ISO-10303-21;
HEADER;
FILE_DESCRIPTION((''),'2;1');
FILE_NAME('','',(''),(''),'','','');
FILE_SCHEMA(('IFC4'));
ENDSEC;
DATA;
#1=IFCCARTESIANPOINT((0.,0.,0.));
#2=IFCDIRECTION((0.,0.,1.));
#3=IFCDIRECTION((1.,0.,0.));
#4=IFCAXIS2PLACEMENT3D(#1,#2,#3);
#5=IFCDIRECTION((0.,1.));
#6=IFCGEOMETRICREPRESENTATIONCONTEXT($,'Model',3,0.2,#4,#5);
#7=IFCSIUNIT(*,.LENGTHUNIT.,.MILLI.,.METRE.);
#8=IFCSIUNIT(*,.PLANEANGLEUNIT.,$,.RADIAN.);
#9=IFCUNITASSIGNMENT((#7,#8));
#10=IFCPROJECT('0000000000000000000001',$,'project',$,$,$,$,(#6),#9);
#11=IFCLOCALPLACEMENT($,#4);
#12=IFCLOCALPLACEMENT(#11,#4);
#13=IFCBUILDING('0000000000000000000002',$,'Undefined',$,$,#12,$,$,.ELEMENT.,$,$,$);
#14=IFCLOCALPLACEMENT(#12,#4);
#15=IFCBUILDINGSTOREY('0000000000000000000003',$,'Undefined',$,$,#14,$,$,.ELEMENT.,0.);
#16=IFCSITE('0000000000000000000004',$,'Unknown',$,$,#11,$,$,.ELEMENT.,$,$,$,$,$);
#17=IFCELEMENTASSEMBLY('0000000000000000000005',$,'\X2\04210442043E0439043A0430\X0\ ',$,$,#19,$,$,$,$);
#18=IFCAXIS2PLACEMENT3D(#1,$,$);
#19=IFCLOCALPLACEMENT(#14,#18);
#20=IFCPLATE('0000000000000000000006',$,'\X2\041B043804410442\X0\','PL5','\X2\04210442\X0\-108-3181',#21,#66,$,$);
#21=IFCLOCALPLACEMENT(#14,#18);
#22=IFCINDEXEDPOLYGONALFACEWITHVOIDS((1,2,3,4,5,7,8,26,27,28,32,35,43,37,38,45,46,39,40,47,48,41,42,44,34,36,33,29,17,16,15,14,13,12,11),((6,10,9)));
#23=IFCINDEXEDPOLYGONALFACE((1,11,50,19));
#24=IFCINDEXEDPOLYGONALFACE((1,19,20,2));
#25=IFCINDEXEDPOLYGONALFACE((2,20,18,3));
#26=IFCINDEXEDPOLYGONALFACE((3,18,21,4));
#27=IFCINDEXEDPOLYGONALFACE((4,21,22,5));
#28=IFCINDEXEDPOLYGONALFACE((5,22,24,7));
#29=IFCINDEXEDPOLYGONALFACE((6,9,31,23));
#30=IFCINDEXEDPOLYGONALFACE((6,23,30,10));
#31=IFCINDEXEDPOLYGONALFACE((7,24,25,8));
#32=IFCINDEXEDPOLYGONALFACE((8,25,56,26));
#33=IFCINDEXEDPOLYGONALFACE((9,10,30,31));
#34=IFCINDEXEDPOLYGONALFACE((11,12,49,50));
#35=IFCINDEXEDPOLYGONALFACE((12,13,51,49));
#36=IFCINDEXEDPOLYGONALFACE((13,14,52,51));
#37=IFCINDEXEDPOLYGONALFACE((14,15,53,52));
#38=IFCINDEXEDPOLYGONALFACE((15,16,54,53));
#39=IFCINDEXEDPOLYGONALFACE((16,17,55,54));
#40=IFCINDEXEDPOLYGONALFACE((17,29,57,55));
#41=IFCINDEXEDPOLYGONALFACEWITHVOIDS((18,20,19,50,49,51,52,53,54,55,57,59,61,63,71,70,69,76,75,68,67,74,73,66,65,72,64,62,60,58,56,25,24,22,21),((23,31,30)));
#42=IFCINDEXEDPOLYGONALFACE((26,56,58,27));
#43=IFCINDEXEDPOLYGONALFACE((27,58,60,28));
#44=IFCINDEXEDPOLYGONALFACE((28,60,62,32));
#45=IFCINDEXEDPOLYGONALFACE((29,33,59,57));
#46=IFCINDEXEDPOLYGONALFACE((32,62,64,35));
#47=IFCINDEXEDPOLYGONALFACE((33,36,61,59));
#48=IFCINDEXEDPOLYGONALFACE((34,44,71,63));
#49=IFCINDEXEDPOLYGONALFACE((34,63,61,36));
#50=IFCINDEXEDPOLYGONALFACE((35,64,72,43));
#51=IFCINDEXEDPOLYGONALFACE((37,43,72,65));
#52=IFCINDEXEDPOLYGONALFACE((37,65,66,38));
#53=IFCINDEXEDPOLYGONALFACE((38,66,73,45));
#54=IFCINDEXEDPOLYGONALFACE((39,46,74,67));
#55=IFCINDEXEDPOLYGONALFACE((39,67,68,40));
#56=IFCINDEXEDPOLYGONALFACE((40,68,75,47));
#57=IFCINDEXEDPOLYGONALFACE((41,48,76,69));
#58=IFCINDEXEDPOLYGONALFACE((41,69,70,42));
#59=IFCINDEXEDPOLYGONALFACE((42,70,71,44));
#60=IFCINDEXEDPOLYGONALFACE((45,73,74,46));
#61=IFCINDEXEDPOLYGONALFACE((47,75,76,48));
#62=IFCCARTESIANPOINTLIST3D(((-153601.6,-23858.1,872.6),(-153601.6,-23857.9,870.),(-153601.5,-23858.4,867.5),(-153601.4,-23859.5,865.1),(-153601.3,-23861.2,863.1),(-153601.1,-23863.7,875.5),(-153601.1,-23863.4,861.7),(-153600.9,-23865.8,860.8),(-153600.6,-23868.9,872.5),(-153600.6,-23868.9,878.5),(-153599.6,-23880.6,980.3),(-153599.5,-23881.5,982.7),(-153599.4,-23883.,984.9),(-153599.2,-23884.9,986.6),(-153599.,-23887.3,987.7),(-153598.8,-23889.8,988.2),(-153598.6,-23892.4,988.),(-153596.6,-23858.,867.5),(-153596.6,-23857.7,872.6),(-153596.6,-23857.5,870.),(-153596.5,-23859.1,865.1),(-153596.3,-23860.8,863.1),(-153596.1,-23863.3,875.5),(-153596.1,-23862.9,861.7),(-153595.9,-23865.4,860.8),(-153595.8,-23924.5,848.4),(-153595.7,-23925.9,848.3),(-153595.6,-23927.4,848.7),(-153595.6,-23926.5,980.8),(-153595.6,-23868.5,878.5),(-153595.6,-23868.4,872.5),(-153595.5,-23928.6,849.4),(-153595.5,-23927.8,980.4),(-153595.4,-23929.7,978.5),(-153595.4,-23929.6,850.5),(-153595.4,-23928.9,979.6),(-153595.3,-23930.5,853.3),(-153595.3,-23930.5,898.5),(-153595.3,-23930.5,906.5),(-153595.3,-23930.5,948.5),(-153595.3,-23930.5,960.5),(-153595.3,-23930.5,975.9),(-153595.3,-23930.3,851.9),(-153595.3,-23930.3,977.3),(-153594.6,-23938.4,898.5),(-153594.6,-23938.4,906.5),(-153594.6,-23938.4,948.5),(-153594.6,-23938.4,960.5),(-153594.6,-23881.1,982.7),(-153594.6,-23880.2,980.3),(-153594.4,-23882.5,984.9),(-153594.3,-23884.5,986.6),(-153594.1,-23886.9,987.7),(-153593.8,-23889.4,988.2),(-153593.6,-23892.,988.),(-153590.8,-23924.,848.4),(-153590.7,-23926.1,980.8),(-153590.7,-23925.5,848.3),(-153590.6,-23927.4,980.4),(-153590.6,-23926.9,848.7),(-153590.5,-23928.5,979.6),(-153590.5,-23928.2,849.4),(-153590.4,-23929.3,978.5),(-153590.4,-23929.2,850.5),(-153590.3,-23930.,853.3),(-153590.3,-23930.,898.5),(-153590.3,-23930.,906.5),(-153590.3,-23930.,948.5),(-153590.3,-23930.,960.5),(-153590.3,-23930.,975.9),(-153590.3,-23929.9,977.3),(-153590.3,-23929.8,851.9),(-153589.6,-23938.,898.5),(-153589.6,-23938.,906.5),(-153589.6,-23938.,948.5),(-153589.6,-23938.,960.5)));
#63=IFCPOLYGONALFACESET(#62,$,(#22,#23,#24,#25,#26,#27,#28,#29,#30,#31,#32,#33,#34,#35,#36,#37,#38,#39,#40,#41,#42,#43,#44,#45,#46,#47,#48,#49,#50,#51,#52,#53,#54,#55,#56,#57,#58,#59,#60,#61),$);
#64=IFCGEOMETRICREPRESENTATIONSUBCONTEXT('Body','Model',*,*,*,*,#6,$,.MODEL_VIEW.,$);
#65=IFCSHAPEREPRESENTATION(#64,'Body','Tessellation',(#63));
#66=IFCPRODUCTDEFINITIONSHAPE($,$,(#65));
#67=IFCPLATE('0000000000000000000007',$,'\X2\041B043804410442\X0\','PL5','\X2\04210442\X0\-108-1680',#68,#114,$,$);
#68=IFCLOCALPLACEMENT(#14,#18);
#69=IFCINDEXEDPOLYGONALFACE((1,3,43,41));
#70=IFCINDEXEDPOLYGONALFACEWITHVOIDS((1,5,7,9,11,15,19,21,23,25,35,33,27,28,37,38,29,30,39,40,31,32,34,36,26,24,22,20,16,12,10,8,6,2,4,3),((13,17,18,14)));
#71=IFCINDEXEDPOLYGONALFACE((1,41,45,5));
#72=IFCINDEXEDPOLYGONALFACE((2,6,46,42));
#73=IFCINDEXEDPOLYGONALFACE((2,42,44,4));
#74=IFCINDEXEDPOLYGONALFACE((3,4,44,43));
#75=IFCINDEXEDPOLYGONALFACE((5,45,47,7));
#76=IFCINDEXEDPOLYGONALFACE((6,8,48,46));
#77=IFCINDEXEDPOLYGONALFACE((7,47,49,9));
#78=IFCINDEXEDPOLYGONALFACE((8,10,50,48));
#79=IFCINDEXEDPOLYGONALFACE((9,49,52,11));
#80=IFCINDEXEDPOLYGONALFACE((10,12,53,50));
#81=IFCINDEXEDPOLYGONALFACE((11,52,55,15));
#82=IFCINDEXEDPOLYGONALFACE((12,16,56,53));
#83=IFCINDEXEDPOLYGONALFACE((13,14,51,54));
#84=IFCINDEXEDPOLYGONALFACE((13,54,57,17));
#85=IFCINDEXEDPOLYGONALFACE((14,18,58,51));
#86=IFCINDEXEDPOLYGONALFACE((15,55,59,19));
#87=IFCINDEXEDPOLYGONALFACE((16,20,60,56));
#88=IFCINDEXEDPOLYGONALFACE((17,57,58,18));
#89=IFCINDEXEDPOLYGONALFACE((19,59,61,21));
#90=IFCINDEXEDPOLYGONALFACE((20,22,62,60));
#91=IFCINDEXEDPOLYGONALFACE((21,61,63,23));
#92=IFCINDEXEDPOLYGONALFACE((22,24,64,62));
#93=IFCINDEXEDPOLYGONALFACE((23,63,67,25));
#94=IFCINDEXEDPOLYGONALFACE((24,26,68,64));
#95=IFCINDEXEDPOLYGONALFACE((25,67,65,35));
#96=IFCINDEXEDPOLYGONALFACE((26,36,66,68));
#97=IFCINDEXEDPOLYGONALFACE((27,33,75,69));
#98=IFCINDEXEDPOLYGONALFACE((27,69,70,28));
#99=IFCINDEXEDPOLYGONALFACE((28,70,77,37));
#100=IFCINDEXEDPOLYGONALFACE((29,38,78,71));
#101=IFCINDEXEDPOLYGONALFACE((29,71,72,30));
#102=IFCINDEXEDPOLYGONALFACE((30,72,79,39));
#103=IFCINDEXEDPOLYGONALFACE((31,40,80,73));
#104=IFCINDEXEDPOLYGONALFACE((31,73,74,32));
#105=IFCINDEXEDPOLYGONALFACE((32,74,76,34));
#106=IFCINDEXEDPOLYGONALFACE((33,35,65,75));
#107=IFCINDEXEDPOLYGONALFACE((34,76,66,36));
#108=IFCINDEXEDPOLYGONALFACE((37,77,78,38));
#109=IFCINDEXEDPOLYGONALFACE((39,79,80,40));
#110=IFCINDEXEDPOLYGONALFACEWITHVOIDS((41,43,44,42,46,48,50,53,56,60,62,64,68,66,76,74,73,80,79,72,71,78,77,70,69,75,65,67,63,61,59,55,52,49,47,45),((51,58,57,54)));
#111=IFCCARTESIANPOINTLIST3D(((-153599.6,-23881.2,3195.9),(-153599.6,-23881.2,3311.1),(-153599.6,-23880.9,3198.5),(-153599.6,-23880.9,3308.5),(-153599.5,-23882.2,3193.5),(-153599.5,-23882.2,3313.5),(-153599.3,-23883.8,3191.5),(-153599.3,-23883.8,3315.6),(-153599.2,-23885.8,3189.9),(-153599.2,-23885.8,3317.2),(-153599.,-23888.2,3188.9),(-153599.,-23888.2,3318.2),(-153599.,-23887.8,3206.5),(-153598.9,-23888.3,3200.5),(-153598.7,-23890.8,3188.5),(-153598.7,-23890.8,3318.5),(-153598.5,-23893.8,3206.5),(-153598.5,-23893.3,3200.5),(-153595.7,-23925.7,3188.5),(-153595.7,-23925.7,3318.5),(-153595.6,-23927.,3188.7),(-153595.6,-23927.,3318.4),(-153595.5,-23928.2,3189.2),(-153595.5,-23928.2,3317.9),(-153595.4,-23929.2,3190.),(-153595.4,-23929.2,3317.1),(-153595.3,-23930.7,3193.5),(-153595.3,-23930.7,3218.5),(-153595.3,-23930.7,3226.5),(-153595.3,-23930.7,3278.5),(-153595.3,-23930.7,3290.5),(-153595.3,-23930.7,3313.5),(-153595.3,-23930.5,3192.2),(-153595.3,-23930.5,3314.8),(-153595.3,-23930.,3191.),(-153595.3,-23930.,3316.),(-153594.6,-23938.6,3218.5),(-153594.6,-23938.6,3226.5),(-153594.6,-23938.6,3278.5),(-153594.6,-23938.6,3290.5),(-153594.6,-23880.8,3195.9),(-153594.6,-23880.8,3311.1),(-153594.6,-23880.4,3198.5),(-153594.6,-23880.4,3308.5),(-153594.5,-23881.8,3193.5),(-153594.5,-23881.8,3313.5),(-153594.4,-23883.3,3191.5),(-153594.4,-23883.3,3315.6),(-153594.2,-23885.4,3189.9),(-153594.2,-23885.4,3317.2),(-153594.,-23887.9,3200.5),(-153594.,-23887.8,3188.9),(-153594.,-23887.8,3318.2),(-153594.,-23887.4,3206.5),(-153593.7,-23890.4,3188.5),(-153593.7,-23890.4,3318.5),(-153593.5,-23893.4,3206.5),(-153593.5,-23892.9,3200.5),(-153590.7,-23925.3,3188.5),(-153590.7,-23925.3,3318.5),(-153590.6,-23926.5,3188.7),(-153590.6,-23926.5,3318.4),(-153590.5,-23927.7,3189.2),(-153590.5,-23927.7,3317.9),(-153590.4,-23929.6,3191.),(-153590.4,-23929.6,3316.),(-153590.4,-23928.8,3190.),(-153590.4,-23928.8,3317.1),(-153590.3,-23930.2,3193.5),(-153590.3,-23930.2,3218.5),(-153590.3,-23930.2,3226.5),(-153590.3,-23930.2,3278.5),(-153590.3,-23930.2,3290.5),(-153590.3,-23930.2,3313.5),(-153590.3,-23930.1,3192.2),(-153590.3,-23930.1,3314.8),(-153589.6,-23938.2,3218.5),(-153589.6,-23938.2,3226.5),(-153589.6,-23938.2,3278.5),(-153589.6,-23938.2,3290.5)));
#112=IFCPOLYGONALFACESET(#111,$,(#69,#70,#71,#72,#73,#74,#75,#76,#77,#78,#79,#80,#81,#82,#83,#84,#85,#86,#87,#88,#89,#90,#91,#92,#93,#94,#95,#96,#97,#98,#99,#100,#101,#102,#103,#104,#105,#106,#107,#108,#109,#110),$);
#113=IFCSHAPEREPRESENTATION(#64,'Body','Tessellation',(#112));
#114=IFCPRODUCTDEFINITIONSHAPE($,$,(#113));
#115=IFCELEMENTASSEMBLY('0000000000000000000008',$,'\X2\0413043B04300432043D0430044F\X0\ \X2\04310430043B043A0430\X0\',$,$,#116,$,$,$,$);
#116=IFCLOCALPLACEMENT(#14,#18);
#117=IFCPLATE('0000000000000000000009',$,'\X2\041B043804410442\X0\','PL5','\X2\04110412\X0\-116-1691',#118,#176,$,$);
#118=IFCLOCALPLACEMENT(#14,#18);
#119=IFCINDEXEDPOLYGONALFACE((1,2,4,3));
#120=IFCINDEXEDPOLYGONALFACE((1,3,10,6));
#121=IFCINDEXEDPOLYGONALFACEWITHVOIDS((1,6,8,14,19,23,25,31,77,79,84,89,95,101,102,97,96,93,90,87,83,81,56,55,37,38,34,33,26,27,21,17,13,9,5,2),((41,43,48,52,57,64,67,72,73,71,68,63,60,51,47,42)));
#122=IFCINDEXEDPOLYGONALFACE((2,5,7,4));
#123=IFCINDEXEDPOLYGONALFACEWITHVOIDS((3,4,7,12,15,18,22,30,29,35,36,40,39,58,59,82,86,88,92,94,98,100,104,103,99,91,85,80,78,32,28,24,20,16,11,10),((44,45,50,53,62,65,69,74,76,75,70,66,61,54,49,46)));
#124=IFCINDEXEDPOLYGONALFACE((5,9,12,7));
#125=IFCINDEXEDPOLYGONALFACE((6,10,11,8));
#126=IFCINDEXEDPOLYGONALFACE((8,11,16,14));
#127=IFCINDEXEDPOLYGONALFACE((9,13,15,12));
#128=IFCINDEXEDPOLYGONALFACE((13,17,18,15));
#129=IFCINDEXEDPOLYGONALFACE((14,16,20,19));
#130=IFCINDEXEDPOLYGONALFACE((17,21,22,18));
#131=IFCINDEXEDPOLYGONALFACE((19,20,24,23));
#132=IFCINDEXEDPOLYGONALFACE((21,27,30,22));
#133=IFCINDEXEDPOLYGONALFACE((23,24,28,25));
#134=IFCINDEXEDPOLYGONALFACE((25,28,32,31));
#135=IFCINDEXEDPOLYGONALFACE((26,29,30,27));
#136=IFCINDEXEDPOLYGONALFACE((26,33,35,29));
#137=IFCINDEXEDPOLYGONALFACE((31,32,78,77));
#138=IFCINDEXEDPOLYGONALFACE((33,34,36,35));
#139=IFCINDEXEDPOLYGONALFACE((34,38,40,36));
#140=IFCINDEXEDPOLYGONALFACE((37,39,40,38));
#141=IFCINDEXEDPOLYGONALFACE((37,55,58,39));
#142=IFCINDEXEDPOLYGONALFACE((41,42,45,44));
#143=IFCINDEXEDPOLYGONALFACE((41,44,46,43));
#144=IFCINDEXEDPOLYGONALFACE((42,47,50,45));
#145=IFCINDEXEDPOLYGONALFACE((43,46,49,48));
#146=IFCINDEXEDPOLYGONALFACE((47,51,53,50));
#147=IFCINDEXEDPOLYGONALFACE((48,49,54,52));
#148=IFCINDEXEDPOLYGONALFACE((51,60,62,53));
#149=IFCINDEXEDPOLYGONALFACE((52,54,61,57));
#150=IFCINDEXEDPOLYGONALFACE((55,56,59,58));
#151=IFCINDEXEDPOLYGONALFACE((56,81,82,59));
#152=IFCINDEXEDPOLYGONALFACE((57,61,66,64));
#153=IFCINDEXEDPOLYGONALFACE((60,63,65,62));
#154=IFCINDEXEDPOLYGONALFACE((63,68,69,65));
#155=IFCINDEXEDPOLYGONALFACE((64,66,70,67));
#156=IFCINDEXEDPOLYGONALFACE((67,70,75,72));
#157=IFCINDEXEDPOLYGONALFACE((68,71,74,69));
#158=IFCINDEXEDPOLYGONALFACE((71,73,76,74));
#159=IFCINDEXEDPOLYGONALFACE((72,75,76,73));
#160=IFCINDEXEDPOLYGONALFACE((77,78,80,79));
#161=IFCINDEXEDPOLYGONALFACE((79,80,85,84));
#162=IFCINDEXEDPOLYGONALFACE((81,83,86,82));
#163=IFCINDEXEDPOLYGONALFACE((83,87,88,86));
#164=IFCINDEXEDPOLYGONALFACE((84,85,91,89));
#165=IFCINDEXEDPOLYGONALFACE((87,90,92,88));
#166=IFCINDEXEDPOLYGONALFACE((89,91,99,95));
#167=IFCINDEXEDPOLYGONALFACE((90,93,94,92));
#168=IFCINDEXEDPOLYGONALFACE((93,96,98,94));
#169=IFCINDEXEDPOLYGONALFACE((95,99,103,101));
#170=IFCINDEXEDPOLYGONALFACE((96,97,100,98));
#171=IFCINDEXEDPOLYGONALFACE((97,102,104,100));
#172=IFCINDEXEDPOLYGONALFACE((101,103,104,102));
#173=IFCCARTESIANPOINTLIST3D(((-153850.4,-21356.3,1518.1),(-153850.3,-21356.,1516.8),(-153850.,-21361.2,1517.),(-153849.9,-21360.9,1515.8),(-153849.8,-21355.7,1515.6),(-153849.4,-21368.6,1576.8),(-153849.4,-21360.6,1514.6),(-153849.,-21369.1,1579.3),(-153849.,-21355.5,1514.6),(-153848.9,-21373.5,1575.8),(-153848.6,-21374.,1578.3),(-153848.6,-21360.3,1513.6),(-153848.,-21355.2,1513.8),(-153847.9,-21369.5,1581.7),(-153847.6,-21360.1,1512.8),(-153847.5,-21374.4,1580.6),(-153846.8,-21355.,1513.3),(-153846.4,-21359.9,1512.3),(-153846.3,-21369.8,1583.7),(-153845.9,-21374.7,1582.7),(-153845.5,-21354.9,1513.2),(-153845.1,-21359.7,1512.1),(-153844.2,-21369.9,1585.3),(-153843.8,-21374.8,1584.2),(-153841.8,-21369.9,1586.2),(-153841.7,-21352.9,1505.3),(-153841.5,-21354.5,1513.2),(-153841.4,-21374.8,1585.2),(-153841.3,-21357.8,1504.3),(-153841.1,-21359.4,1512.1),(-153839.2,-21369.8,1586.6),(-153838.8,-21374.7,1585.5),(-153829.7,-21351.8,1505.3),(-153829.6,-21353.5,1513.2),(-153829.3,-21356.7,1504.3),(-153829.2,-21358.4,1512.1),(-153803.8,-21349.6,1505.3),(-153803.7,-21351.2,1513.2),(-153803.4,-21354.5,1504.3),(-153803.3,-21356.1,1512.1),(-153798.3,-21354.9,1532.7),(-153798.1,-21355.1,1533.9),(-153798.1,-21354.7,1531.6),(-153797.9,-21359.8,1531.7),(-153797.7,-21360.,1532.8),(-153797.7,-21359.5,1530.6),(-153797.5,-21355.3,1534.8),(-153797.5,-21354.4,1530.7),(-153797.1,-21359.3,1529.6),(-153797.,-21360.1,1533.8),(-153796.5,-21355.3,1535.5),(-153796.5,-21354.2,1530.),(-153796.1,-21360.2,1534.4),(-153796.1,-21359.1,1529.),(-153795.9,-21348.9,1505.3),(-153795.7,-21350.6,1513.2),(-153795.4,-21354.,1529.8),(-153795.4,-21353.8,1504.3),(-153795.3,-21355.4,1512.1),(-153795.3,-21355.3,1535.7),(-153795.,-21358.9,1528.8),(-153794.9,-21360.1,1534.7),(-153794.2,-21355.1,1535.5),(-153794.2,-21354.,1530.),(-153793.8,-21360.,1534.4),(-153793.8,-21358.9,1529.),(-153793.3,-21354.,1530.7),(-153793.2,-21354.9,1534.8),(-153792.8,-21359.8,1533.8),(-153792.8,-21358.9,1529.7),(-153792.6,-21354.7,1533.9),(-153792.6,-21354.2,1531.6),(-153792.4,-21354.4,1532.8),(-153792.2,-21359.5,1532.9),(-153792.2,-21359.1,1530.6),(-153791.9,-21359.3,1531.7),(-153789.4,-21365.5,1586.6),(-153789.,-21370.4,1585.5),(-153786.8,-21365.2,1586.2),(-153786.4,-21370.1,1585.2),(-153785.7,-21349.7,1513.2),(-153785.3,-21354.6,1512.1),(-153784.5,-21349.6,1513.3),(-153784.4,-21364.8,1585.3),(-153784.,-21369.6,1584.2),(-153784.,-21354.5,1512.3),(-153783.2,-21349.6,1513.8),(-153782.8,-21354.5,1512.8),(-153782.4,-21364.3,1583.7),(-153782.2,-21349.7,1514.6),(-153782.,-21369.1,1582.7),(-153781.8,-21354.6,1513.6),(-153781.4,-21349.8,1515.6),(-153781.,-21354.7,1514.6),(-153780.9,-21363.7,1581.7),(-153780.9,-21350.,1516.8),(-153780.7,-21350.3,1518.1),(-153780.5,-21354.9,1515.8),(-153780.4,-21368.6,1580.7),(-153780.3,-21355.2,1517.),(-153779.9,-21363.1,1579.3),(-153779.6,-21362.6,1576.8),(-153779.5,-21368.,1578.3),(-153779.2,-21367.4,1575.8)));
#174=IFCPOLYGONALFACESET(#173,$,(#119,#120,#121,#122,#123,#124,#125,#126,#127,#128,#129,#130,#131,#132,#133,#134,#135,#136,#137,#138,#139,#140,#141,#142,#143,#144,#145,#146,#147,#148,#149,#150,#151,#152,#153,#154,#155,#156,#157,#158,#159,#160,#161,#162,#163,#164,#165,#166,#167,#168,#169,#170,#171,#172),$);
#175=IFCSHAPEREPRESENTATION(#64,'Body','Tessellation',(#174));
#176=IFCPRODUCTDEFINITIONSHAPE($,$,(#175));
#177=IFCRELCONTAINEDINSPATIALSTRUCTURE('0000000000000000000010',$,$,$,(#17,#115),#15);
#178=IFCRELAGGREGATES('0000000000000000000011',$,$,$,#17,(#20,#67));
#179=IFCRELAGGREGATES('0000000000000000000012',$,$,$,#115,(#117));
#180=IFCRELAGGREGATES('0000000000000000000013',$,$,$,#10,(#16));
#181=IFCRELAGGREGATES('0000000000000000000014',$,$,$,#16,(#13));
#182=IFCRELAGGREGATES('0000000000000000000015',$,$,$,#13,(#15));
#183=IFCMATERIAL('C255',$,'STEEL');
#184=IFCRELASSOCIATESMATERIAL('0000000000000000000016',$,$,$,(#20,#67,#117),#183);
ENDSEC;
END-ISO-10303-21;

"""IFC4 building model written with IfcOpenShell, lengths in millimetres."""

from ifc_helpers import new_model, si_unit, direction, frame, origin_with_axes, place, context, subcontext, project, spatial, line, arc, indexed_curve, outline, extrude, material, element, aggregate, save


model = new_model("IFC4")

# Units and contexts
model_context = context("Model", 3, precision=0.2, world=origin_with_axes(), true_north=direction((0.0, 1.0)))
body_context = subcontext(model_context, "Body", "Model", "MODEL_VIEW")
ifc_project = project(units=[si_unit("LENGTHUNIT", "METRE", prefix="MILLI"), si_unit("PLANEANGLEUNIT", "RADIAN")], contexts=[model_context])

# Site, building, storey
site_placement = place(None, origin_with_axes())
site = spatial("IfcSite", under=ifc_project, at=site_placement, Name="Unknown", CompositionType="ELEMENT")
building_placement = place(site_placement, origin_with_axes())
building = spatial("IfcBuilding", under=site, at=building_placement, Name="Undefined", CompositionType="ELEMENT")
storey_placement = place(building_placement, origin_with_axes())
storey = spatial("IfcBuildingStorey", under=building, at=storey_placement, Name="Undefined", CompositionType="ELEMENT", Elevation=0.0)

# Element assemblies, plates, voiding features
ifc_material_1 = material(Name="C255", Category="STEEL")
assembly_1_placement = place(storey_placement, frame((-153594.3, -23970.7, 698.5), z_axis=(-0.086114, 0.996285, 0.0), x_axis=(0.0, 0.0, 1.0)))
assembly_1 = element("IfcElementAssembly", 1, at=assembly_1_placement, inside=storey, Name="Стойка ")
plate_1_placement = place(assembly_1_placement, frame((164.3, 5.0, 114.9), z_axis=(-0.000024, 1.0, 0.0), x_axis=(0.978653, 0.000024, -0.205517)))
plate_1 = element("IfcPlate", 2, at=plate_1_placement, material=ifc_material_1, Name="Лист", Description="PL5", ObjectType="Ст-108-3181", context=body_context, shape_type="SolidModel", body=[
    extrude(outline(indexed_curve([(0.0, 10.0), (2.9, 2.9), (10.0, 0.0), (120.0, 0.0), (127.1, 2.9), (130.0, 10.0), (130.0, 44.9), (128.9, 48.1), (126.0, 49.8), (110.9, 53.0), (112.6, 60.8), (100.8, 63.3), (99.2, 55.5), (58.1, 64.1), (59.7, 71.9), (51.9, 73.6), (50.3, 65.7), (6.0, 75.0), (1.8, 74.0), (0.0, 70.1)], segments=[arc(1, 2, 3), line(3, 4), arc(4, 5, 6), line(6, 7), arc(7, 8, 9), line(9, 10, 11, 12, 13, 14, 15, 16, 17, 18), arc(18, 19, 20), line(20, 1)])), frame((0.0, 0.0, 2.5), z_axis=(0.0, 0.0, 1.0), x_axis=(1.0, 0.0, 0.0)), (0.0, 0.0, -1.0), 5.0),
])
voiding_feature_1_placement = place(plate_1_placement, frame((15.0, 10.0, 10.0), z_axis=(-0.202559, -0.97927, 0.0), x_axis=(0.0, 0.0, -1.0)))
element("IfcVoidingFeature", 3, at=voiding_feature_1_placement, cuts=plate_1, Name="Балка", ObjectType="(?)", PredefinedType="HOLE", context=body_context, shape_type="SolidModel", body=[
    extrude(outline(indexed_curve([(0.0, -3.0), (5.2, 0.0), (0.0, 3.0)], segments=[line(1, 2, 3, 1)])), frame((0.0, 0.0, 0.0), z_axis=(-1.0, 0.0, 0.0), x_axis=(0.0, 0.0, 1.0)), (0.0, 0.0, -1.0), 20.0),
])
plate_2_placement = place(assembly_1_placement, frame((2490.0, 5.0, 90.0), z_axis=(0.000024, 1.0, 0.0), x_axis=(1.0, -0.000024, 0.0)))
plate_2 = element("IfcPlate", 4, at=plate_2_placement, material=ifc_material_1, Name="Лист", Description="PL5", ObjectType="Ст-108-1680", context=body_context, shape_type="SolidModel", body=[
    extrude(outline(indexed_curve([(0.0, 10.0), (2.9, 2.9), (10.0, 0.0), (120.0, 0.0), (127.1, 2.9), (130.0, 10.0), (130.0, 45.0), (128.5, 48.5), (125.0, 50.0), (102.0, 50.0), (102.0, 58.0), (90.0, 58.0), (90.0, 50.0), (38.0, 50.0), (38.0, 58.0), (30.0, 58.0), (30.0, 50.0), (5.0, 50.0), (1.5, 48.5), (0.0, 45.0)], segments=[arc(1, 2, 3), line(3, 4), arc(4, 5, 6), line(6, 7), arc(7, 8, 9), line(9, 10, 11, 12, 13, 14, 15, 16, 17, 18), arc(18, 19, 20), line(20, 1)])), frame((0.0, 0.0, 2.5), z_axis=(0.0, 0.0, 1.0), x_axis=(1.0, 0.0, 0.0)), (0.0, 0.0, -1.0), 5.0),
])
voiding_feature_2_placement = place(plate_2_placement, frame((15.0, 10.0, 10.0), z_axis=(0.003022, -0.999995, 0.0), x_axis=(0.0, 0.0, -1.0)))
element("IfcVoidingFeature", 5, at=voiding_feature_2_placement, cuts=plate_2, Name="Балка", ObjectType="(?)", PredefinedType="HOLE", context=body_context, shape_type="SolidModel", body=[
    extrude(outline(indexed_curve([(2.5, -3.0), (3.0, 3.0), (-3.0, 3.0), (-2.5, -3.0)], segments=[line(1, 2, 3, 4, 1)])), frame((0.0, 0.0, 0.0), z_axis=(-1.0, 0.0, 0.0), x_axis=(0.0, 0.0, 1.0)), (0.0, 0.0, -1.0), 20.0),
])
assembly_2_placement = place(storey_placement, frame((-153839.8, -21131.3, 1498.5), z_axis=(-0.996285, -0.086114, 0.000024), x_axis=(0.084276, -0.975018, -0.205517)))
assembly_2 = element("IfcElementAssembly", 6, at=assembly_2_placement, inside=storey, Name="Главная балка")
plate_3_placement = place(assembly_2_placement, frame((217.0, 135.0, -40.0), z_axis=(1.0, 0.000054, 0.0), x_axis=(0.0, -0.000054, 1.0)))
plate_3 = element("IfcPlate", 7, at=plate_3_placement, material=ifc_material_1, Name="Лист", Description="PL5", ObjectType="БВ-116-1691", context=body_context, shape_type="SolidModel", body=[
    extrude(outline(indexed_curve([(0.0, 10.0), (2.9, 2.9), (10.0, 0.0), (60.0, 0.0), (67.1, 2.9), (70.0, 10.0), (70.0, 70.0), (68.5, 73.5), (65.0, 75.0), (61.0, 75.0), (61.0, 83.0), (49.0, 83.0), (49.0, 75.0), (23.0, 75.0), (23.0, 83.0), (15.0, 83.0), (15.0, 75.0), (5.0, 75.0), (1.5, 73.5), (0.0, 70.0)], segments=[arc(1, 2, 3), line(3, 4), arc(4, 5, 6), line(6, 7), arc(7, 8, 9), line(9, 10, 11, 12, 13, 14, 15, 16, 17, 18), arc(18, 19, 20), line(20, 1)])), frame((0.0, 0.0, 2.5), z_axis=(0.0, 0.0, 1.0), x_axis=(1.0, 0.0, 0.0)), (0.0, 0.0, -1.0), 5.0),
])
voiding_feature_3_placement = place(plate_3_placement, frame((15.0, 55.0, 10.0), z_axis=(0.007997, -0.999968, -0.000026), x_axis=(0.0, 0.000026, -1.0)))
element("IfcVoidingFeature", 8, at=voiding_feature_3_placement, cuts=plate_3, Name="Балка", ObjectType="(?)", PredefinedType="HOLE", context=body_context, shape_type="SolidModel", body=[
    extrude(outline(indexed_curve([(3.0, 0.0), (2.8, 1.1), (2.1, 2.1), (1.1, 2.8), (0.0, 3.0), (-1.1, 2.8), (-2.1, 2.1), (-2.8, 1.1), (-3.0, 0.0), (-2.8, -1.1), (-2.1, -2.1), (-1.1, -2.8), (0.0, -3.0), (1.1, -2.8), (2.1, -2.1), (2.8, -1.1)], segments=[line(1, 2, 3, 4, 5, 6, 7, 8, 9, 10, 11, 12, 13, 14, 15, 16, 1)])), frame((0.0, 0.0, 0.0), z_axis=(-1.0, 0.0, 0.0), x_axis=(0.0, 0.0, 1.0)), (0.0, 0.0, -1.0), 20.0),
])

aggregate(assembly_1, [plate_1, plate_2])
aggregate(assembly_2, [plate_3])

save(model, "model.ifc")
